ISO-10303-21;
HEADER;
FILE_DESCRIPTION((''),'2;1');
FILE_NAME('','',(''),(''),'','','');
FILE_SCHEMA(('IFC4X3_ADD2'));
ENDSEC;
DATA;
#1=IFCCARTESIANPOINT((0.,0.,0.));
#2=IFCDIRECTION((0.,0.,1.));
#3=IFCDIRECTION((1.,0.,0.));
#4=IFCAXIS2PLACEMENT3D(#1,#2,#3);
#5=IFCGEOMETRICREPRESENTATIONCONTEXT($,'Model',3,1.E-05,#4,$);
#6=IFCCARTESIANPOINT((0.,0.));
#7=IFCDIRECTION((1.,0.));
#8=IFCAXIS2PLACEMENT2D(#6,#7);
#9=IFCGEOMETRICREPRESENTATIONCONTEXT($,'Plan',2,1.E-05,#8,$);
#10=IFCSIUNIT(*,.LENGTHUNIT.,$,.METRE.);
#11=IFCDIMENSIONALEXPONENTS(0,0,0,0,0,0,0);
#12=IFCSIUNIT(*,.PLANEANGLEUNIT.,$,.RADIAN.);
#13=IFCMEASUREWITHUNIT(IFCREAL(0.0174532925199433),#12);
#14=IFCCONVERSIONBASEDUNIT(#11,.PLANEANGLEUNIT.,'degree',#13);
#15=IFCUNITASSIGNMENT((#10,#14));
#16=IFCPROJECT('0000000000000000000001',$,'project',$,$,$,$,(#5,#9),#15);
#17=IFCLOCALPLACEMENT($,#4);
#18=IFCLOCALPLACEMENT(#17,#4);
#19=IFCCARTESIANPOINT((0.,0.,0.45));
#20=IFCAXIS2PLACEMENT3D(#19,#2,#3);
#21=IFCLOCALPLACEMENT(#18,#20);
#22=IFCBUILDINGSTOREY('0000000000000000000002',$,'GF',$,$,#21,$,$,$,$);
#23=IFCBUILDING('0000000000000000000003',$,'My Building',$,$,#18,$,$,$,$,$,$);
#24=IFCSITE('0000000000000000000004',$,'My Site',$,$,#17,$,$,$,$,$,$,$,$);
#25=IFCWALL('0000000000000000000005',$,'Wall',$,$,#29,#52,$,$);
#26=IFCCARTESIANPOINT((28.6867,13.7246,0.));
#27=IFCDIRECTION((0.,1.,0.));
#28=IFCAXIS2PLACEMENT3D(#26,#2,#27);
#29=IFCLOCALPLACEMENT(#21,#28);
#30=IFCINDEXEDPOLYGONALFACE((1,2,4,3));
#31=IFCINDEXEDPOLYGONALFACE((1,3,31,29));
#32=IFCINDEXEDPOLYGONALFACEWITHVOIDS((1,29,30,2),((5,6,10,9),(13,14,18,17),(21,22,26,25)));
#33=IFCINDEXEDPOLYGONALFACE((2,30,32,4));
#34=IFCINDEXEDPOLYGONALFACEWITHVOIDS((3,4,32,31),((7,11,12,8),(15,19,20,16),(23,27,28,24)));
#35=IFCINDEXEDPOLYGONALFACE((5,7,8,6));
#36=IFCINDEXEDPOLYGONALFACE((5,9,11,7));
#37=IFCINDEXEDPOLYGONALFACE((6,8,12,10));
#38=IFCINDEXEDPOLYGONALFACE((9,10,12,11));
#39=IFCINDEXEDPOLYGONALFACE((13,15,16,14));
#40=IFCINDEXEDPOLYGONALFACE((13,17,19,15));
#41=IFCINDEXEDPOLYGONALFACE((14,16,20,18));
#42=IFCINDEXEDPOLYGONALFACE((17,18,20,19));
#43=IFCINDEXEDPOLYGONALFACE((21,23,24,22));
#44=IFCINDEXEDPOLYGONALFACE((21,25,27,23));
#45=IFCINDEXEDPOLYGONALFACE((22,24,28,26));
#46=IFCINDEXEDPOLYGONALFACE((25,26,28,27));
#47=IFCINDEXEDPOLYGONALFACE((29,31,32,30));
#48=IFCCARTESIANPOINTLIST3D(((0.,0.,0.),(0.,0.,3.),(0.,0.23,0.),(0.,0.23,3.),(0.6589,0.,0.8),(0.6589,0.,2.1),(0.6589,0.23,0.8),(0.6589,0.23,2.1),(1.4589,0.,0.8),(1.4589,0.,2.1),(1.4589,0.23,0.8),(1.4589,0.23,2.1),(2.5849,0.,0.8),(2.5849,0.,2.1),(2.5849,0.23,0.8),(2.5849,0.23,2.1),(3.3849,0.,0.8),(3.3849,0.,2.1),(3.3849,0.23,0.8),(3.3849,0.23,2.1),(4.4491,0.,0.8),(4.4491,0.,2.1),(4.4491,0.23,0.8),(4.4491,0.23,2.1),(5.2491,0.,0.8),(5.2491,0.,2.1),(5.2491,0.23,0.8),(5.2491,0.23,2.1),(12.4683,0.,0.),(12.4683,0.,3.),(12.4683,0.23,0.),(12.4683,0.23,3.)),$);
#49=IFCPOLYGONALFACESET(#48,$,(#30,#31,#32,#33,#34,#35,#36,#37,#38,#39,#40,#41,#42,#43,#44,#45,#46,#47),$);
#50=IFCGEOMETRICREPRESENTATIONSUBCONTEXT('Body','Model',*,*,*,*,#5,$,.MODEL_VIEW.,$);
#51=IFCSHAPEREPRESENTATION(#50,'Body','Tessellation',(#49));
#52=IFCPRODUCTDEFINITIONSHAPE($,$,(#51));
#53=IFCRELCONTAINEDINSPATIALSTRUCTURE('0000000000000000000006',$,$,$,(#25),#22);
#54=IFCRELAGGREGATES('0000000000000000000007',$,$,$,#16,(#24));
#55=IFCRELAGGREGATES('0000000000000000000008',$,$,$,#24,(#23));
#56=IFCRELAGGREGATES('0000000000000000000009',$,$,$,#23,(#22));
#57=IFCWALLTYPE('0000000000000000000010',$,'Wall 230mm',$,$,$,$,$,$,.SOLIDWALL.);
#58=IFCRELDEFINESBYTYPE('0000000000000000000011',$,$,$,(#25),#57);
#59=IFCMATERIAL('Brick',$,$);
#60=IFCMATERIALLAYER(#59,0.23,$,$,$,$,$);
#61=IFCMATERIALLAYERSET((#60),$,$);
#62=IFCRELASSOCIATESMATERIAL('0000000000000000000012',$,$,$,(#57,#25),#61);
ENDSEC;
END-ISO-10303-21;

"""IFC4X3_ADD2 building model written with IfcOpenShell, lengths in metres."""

from ifc_helpers import new_model, entity, si_unit, converted_unit, frame, origin_with_axes, origin_2d_with_axis, place, context, subcontext, project, spatial, line, indexed_curve, outline, extrude, source, transform, mapped, material, layer, layer_set, layer_usage, type_object, element, save


model = new_model("IFC4X3_ADD2")

# Units and contexts
model_context = context("Model", 3, precision=1e-05, world=origin_with_axes())
plan_context = context("Plan", 2, precision=1e-05, world=origin_2d_with_axis())
body_context_1 = subcontext(model_context, "Body", "Model", "MODEL_VIEW")
ifc_project = project(units=[si_unit("LENGTHUNIT", "METRE"), converted_unit("PLANEANGLEUNIT", "degree", entity("IfcReal", 0.0174532925199433), si_unit("PLANEANGLEUNIT", "RADIAN"), dimensions=[0, 0, 0, 0, 0, 0, 0])], contexts=[model_context, plan_context])

# Site, building, storey
site_placement = place(None, origin_with_axes())
site = spatial("IfcSite", under=ifc_project, at=site_placement, Name="My Site")
building_placement = place(site_placement, origin_with_axes())
building = spatial("IfcBuilding", under=site, at=building_placement, Name="My Building")
storey_placement = place(building_placement, frame((0.0, 0.0, 0.45), z_axis=(0.0, 0.0, 1.0), x_axis=(1.0, 0.0, 0.0)))
storey = spatial("IfcBuildingStorey", under=building, at=storey_placement, Name="GF")

# Wall, openings
ifc_material = material(Name="Brick")
ifc_layer_1 = layer(ifc_material, 0.23)
ifc_layer_set_1 = layer_set([ifc_layer_1])
ifc_layer_usage_1 = layer_usage(ifc_layer_set_1, "AXIS2", "POSITIVE", 0.0)
wall_type_1 = type_object("IfcWallType", Name="Wall 230mm", PredefinedType="SOLIDWALL", material=ifc_layer_set_1)
wall_1_placement = place(storey_placement, frame((28.6867, 13.7246, 0.0), z_axis=(0.0, 0.0, 1.0), x_axis=(0.0, 1.0, 0.0)))
wall_1 = element("IfcWall", 1, at=wall_1_placement, inside=storey, type_object=wall_type_1, material=ifc_layer_usage_1, Name="Wall", context=body_context_1, shape_type="SweptSolid", body=[
    extrude(outline(indexed_curve([(0.0, 0.0), (0.0, 0.23), (12.4683, 0.23), (12.4683, 0.0), (0.0, 0.0)], self_intersect=False)), origin_with_axes(), (0.0, 0.0, 1.0), 3.0),
])
shared_shape_1 = source(origin_with_axes(), body_context_1, "Body", "SweptSolid", [
    extrude(outline(indexed_curve([(0.0, 0.0), (0.8, 0.0), (0.8, 1.3), (0.0, 1.3)], segments=[line(1, 2, 3, 4, 1)])), frame((-0.4, -0.6, 0.0), z_axis=(0.0, -1.0, 0.0), x_axis=(1.0, 0.0, 0.0)), (0.0, 0.0, -1.0), 1.2),
])
opening_1_placement = place(wall_1_placement, frame((1.0589, 0.015, 0.8), z_axis=(0.0, 0.0, 1.0), x_axis=(1.0, 0.0, 0.0)))
element("IfcOpeningElement", 2, at=opening_1_placement, cuts=wall_1, PredefinedType="OPENING", context=body_context_1, shape_type="MappedRepresentation", body=[
    mapped(shared_shape_1, transform((0.0, 0.0, 0.0), x_axis=(1.0, 0.0, 0.0), y_axis=(0.0, 1.0, 0.0), z_axis=(0.0, 0.0, 1.0), scale=1.0)),
])
opening_2_placement = place(wall_1_placement, frame((4.8491, 0.015, 0.8), z_axis=(0.0, 0.0, 1.0), x_axis=(1.0, 0.0, 0.0)))
element("IfcOpeningElement", 3, at=opening_2_placement, cuts=wall_1, PredefinedType="OPENING", context=body_context_1, shape_type="MappedRepresentation", body=[
    mapped(shared_shape_1, transform((0.0, 0.0, 0.0), x_axis=(1.0, 0.0, 0.0), y_axis=(0.0, 1.0, 0.0), z_axis=(0.0, 0.0, 1.0), scale=1.0)),
])
opening_3_placement = place(wall_1_placement, frame((2.9849, 0.015, 0.8), z_axis=(0.0, 0.0, 1.0), x_axis=(1.0, 0.0, 0.0)))
element("IfcOpeningElement", 4, at=opening_3_placement, cuts=wall_1, PredefinedType="OPENING", context=body_context_1, shape_type="MappedRepresentation", body=[
    mapped(shared_shape_1, transform((0.0, 0.0, 0.0), x_axis=(1.0, 0.0, 0.0), y_axis=(0.0, 1.0, 0.0), z_axis=(0.0, 0.0, 1.0), scale=1.0)),
])

save(model, "model.ifc")
